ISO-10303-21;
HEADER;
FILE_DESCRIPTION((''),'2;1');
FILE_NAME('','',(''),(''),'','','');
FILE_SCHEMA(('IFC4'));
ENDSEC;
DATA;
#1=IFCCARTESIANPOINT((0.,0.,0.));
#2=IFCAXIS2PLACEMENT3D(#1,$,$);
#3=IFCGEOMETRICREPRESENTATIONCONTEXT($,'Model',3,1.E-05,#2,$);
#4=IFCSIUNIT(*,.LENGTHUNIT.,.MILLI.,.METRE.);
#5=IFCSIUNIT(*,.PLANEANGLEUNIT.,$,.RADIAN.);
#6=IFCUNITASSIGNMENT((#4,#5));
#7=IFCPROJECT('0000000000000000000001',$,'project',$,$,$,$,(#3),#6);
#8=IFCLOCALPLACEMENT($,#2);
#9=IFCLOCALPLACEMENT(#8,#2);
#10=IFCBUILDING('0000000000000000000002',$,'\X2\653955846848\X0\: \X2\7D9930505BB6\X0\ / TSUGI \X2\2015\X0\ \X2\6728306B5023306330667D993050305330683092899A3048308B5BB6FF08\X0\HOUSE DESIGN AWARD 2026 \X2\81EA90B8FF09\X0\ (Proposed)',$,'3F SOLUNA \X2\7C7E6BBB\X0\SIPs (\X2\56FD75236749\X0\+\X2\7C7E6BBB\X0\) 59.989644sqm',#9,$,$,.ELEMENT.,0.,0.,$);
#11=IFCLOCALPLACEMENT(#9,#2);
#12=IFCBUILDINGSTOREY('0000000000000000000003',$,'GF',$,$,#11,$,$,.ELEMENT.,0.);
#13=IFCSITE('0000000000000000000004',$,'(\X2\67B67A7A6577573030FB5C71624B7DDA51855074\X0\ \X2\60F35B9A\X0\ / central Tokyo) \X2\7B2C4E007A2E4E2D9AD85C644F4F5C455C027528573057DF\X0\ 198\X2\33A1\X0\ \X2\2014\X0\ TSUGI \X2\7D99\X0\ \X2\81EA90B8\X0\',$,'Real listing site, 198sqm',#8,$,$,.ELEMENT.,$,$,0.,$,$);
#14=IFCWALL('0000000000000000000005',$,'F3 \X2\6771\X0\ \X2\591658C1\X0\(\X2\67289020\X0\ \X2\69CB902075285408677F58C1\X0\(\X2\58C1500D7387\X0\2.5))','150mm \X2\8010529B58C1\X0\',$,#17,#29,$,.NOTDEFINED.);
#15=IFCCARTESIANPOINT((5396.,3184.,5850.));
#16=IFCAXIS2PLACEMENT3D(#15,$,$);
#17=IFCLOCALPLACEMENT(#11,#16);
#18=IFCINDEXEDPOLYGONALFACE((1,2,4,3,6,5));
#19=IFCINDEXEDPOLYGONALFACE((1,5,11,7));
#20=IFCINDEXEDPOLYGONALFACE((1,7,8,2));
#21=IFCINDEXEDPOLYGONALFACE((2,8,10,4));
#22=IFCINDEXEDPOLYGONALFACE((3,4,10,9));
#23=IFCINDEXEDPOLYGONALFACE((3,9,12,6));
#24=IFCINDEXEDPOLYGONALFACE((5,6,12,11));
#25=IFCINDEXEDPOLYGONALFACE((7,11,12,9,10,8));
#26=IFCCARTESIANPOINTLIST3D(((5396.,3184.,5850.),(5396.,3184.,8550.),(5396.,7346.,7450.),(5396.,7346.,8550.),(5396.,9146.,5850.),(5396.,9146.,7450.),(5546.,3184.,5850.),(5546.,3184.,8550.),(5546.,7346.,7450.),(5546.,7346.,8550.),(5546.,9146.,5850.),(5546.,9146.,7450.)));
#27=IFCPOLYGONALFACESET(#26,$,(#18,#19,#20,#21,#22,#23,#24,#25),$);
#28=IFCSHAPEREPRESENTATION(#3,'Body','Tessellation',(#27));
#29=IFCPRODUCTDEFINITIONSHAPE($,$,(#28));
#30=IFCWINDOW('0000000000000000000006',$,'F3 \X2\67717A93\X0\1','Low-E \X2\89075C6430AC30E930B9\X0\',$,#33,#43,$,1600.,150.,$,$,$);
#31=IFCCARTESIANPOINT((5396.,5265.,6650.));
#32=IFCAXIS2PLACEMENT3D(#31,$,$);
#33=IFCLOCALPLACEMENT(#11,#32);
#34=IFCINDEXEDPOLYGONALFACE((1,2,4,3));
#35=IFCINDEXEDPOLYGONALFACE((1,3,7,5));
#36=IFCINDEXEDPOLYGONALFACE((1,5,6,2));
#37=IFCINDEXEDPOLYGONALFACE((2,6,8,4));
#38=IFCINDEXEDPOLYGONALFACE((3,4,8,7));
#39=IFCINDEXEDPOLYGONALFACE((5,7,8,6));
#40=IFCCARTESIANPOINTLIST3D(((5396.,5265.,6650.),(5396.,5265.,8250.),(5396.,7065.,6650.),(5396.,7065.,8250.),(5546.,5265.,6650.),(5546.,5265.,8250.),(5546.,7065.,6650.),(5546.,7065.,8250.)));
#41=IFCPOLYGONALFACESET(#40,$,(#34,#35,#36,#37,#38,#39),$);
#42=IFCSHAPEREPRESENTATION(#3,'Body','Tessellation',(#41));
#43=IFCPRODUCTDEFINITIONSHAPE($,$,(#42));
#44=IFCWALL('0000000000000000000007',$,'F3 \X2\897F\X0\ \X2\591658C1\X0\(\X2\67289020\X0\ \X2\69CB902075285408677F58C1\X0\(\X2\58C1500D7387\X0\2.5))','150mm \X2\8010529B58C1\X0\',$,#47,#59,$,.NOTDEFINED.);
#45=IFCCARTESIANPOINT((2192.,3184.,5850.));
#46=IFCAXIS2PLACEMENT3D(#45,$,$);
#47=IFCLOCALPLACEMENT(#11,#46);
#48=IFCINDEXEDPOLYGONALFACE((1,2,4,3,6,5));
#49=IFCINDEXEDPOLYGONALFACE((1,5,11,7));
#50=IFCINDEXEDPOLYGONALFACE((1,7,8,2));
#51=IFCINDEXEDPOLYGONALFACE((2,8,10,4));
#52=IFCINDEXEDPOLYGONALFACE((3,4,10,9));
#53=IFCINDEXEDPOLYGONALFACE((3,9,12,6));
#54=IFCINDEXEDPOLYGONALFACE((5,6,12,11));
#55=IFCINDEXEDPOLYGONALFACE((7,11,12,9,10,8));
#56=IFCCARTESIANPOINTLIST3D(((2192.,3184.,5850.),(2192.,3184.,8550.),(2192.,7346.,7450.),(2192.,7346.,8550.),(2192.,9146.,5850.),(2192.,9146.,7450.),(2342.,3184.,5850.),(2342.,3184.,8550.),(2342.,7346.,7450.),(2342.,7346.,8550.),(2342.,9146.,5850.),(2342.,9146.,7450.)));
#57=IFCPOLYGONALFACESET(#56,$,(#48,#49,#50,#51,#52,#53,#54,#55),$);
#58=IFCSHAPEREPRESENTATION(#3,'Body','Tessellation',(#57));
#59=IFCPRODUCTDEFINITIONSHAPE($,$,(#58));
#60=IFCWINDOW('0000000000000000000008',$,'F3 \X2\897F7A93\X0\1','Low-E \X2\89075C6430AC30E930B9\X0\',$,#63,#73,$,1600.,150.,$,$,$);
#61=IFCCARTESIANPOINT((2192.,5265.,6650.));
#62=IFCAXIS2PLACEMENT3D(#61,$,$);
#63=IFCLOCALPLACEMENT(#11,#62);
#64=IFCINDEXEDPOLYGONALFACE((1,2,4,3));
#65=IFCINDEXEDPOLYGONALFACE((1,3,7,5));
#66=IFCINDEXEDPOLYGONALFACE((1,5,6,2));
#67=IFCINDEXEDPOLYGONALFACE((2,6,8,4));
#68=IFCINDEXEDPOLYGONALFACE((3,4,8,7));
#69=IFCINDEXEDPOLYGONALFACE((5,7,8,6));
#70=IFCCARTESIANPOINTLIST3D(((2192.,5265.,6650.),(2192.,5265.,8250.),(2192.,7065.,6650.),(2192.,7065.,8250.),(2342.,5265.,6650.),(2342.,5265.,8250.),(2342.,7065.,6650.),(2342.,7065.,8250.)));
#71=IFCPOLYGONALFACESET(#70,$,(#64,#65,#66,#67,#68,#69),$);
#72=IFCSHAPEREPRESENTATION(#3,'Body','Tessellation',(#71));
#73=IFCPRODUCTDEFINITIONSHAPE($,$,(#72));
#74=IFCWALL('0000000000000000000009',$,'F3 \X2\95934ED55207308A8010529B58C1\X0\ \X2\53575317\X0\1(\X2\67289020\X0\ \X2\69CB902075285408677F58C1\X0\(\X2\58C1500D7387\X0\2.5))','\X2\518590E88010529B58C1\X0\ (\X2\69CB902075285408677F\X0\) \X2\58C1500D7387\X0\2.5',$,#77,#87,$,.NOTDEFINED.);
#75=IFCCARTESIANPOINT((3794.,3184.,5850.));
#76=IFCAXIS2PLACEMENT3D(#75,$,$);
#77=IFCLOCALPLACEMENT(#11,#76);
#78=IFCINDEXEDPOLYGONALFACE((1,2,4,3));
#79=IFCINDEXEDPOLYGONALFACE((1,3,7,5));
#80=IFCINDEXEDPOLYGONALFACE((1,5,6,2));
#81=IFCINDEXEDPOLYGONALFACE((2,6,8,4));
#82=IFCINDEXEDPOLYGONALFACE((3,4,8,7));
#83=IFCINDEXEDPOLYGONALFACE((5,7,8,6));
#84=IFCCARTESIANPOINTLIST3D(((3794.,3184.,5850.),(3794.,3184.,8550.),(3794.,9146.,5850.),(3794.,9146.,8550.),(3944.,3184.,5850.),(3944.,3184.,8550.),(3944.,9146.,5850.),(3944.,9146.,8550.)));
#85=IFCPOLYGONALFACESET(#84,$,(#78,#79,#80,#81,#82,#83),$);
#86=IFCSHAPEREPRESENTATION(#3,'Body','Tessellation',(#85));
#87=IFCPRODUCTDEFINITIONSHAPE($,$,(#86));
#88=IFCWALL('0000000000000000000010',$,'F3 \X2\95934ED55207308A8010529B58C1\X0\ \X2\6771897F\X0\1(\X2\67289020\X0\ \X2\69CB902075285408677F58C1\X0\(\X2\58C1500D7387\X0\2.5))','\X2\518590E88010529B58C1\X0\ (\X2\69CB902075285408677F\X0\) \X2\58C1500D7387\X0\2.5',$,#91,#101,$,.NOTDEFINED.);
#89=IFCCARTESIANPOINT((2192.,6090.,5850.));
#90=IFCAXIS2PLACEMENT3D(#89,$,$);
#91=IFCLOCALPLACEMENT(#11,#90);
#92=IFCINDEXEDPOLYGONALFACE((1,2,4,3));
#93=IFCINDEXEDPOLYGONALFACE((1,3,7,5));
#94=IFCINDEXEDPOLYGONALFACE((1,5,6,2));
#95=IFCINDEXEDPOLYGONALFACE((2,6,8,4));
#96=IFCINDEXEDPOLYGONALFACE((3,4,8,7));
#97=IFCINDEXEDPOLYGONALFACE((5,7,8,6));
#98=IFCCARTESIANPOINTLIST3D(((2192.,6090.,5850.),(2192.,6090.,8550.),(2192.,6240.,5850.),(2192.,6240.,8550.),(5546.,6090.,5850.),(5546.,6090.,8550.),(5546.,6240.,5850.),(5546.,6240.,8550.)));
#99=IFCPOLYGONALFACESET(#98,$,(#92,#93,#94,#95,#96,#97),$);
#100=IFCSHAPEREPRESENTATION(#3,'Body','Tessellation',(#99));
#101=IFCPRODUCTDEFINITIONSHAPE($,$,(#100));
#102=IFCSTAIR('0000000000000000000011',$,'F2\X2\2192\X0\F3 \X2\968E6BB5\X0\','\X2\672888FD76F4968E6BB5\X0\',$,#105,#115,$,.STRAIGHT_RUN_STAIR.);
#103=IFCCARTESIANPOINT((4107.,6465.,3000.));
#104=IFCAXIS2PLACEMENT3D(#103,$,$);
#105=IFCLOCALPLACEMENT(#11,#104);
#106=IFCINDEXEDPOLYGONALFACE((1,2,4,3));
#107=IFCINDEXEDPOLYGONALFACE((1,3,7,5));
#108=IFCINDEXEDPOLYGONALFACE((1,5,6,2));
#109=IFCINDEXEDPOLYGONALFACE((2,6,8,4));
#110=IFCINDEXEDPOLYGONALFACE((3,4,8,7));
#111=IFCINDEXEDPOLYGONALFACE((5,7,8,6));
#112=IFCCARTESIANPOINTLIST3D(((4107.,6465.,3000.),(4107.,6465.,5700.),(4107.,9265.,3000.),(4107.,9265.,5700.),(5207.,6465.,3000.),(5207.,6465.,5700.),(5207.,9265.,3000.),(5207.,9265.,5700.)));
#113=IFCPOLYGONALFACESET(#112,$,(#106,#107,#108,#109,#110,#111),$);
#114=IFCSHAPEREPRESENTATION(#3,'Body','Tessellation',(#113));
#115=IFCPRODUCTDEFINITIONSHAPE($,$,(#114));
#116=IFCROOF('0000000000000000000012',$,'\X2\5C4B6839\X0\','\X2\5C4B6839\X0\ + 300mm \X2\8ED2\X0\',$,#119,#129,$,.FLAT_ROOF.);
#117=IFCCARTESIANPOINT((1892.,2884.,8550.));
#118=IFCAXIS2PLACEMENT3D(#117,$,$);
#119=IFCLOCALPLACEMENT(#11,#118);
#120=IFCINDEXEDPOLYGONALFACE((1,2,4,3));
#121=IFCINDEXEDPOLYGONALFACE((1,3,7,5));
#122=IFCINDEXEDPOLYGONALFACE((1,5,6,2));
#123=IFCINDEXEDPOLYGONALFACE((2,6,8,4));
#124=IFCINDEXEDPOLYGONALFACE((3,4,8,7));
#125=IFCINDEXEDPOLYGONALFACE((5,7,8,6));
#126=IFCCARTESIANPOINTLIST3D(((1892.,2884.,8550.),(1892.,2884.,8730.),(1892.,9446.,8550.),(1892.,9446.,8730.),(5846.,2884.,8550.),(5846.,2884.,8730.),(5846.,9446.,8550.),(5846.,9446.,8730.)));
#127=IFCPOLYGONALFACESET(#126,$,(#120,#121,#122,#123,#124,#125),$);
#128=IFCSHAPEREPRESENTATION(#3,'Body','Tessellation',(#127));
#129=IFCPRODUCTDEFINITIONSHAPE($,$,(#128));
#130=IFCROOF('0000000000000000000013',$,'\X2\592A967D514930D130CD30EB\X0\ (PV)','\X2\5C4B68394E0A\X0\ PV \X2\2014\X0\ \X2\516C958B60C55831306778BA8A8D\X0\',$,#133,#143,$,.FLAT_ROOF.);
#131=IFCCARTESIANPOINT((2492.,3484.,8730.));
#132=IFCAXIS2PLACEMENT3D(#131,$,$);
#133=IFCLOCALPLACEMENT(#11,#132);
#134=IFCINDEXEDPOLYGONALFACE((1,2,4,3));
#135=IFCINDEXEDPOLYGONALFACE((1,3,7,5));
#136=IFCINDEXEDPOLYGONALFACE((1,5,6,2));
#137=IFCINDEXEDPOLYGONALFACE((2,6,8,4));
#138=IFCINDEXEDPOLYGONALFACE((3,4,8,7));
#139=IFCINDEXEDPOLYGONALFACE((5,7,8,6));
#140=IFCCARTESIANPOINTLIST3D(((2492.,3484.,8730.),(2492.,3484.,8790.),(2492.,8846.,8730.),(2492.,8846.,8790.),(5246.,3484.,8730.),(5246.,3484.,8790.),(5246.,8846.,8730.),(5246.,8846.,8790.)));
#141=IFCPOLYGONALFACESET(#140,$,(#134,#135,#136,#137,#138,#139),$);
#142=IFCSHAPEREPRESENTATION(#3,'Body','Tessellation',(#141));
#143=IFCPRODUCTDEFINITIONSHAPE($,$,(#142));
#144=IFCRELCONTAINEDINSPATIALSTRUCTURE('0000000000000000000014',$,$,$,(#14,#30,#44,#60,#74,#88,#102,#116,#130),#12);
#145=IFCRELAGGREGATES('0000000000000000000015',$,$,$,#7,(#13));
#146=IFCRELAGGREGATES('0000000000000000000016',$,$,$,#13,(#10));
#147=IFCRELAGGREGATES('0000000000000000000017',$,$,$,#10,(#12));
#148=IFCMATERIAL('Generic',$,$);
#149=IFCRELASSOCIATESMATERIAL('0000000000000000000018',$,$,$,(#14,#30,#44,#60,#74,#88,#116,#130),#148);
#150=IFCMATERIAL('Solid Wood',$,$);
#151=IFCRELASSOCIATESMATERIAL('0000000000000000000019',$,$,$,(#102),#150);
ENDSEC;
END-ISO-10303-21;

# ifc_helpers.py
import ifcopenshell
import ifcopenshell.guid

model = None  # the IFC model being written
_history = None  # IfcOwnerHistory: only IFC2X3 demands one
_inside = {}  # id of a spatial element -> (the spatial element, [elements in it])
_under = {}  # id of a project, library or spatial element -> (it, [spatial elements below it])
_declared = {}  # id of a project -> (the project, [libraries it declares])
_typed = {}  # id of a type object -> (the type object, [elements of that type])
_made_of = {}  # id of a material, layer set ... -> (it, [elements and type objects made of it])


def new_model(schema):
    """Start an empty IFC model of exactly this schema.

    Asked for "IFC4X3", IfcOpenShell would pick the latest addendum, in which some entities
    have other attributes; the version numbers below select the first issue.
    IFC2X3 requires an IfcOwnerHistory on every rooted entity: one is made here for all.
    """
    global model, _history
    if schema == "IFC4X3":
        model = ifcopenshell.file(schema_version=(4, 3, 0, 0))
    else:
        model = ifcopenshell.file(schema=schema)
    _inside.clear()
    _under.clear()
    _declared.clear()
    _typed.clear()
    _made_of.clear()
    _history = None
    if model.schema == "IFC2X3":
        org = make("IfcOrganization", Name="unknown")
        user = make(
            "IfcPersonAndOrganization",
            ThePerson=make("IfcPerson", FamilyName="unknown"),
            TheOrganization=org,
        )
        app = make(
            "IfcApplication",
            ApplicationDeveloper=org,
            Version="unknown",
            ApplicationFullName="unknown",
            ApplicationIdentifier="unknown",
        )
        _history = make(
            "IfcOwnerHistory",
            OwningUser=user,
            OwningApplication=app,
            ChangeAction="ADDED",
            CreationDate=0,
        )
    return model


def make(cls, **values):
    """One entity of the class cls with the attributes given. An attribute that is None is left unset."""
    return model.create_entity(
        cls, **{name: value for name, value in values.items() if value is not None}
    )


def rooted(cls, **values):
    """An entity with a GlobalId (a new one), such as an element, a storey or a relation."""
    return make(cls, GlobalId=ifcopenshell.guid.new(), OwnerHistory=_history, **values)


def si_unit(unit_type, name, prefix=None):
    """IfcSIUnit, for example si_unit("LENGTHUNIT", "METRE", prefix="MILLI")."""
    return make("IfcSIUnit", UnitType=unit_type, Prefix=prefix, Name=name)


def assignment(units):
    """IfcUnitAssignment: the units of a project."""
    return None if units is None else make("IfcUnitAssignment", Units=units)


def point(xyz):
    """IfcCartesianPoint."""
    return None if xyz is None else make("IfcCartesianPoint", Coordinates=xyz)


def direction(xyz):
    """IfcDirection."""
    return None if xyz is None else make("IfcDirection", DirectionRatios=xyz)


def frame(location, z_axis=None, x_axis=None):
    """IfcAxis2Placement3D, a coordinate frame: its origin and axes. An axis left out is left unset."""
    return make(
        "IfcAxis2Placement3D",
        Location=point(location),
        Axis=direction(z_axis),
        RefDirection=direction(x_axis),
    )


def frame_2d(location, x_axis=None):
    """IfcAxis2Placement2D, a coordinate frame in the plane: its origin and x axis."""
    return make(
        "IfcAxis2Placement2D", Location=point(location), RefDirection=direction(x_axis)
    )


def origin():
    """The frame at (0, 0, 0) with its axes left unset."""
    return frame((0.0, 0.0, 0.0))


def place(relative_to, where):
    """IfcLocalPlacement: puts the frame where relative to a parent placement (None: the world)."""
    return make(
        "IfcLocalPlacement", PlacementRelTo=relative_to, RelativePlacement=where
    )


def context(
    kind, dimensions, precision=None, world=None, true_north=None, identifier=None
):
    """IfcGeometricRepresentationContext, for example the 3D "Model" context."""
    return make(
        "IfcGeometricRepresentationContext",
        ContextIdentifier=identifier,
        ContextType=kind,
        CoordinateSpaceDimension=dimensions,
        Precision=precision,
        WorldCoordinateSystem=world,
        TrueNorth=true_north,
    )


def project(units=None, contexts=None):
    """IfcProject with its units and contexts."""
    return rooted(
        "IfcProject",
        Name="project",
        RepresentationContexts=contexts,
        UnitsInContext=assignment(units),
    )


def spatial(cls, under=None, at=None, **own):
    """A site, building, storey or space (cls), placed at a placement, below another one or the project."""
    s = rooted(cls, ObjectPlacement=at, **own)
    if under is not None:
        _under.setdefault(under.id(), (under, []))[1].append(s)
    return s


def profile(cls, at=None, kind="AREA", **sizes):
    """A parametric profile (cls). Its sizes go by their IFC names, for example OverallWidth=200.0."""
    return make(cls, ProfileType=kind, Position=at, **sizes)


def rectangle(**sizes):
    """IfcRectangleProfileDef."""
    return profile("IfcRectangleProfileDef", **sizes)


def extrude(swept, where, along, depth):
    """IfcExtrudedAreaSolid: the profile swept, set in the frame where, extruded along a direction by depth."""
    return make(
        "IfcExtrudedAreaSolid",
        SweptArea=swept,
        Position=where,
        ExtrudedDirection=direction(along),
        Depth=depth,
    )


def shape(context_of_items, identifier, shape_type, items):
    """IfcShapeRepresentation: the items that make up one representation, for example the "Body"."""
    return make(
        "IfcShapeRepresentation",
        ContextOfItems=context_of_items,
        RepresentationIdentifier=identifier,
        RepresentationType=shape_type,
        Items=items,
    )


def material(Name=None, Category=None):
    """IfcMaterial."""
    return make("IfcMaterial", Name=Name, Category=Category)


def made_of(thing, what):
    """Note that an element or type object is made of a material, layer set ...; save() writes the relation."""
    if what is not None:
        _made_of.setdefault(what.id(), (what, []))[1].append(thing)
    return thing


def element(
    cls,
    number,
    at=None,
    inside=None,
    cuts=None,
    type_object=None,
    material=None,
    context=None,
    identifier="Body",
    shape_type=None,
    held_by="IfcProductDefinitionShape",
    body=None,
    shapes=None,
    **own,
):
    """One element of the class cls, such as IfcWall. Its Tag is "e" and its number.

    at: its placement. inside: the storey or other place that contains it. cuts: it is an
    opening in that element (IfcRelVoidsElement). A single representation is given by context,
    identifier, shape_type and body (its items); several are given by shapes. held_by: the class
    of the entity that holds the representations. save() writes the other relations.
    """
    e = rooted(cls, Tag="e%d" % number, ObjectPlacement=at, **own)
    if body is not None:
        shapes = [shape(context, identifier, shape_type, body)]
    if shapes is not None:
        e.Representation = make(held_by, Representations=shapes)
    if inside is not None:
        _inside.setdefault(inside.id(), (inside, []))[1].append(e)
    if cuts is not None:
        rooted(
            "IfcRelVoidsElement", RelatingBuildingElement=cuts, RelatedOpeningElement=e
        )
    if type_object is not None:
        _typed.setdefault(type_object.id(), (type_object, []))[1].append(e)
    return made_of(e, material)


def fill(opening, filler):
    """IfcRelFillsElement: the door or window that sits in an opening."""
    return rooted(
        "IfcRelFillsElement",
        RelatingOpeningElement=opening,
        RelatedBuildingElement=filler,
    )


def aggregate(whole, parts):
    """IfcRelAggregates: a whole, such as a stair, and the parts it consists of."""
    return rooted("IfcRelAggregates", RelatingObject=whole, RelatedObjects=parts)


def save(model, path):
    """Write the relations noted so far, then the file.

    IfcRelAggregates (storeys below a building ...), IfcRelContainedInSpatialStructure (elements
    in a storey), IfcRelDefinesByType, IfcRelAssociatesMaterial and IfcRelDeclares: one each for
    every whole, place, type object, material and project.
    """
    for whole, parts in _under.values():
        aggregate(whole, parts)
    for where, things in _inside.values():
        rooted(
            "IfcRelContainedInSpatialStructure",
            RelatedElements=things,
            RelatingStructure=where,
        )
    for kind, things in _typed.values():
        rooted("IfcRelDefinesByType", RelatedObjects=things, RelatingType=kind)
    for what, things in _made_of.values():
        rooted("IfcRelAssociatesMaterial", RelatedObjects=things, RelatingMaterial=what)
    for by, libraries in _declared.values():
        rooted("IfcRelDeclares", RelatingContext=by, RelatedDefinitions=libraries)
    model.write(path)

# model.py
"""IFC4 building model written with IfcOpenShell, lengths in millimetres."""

from ifc_helpers import new_model, si_unit, frame, frame_2d, origin, place, context, project, spatial, rectangle, extrude, material, element, fill, save


model = new_model("IFC4")

# Units and contexts
model_context = context("Model", 3, precision=1e-05, world=origin())
ifc_project = project(units=[si_unit("LENGTHUNIT", "METRE", prefix="MILLI"), si_unit("PLANEANGLEUNIT", "RADIAN")], contexts=[model_context])

# Site, building, storey
site_placement = place(None, origin())
site = spatial("IfcSite", under=ifc_project, at=site_placement, Name="(架空敷地・山手線内側 想定 / central Tokyo) 第一種中高層住居専用地域 198㎡ — TSUGI 継 自邸", ObjectType="Real listing site, 198sqm", CompositionType="ELEMENT", RefElevation=0.0)
building_placement = place(site_placement, origin())
building = spatial("IfcBuilding", under=site, at=building_placement, Name="改善案: 継ぐ家 / TSUGI ― 木に倣って継ぐことを覚える家（HOUSE DESIGN AWARD 2026 自邸） (Proposed)", ObjectType="3F SOLUNA 籾殻SIPs (国産杉+籾殻) 59.989644sqm", CompositionType="ELEMENT", ElevationOfRefHeight=0.0, ElevationOfTerrain=0.0)
storey_placement = place(building_placement, origin())
storey = spatial("IfcBuildingStorey", under=building, at=storey_placement, Name="GF", CompositionType="ELEMENT", Elevation=0.0)

# Shared definitions
ifc_material_1 = material(Name="Generic")

# Walls, openings, windows
wall_1_placement = place(storey_placement, frame((5396.0, 3184.0, 5850.0)))
wall_1 = element("IfcWall", 1, at=wall_1_placement, inside=storey, material=ifc_material_1, Name="F3 東 外壁(木造 構造用合板壁(壁倍率2.5))", Description="150mm 耐力壁", PredefinedType="NOTDEFINED", context=model_context, shape_type="SweptSolid", body=[
    extrude(rectangle(XDim=150.0, YDim=5962.0, at=frame_2d((75.0, 2981.0))), frame((5396.0, 3184.0, 5850.0)), (0.0, 0.0, 1.0), 2700.0),
])
opening_1_placement = place(storey_placement, frame((5396.0, 5265.0, 6650.0)))
opening_1 = element("IfcOpeningElement", 2, at=opening_1_placement, cuts=wall_1, PredefinedType="NOTDEFINED", context=model_context, shape_type="SweptSolid", body=[
    extrude(rectangle(XDim=150.0, YDim=1800.0, at=frame_2d((75.0, 900.0))), frame((5396.0, 5265.0, 6650.0)), (0.0, 0.0, 1.0), 1600.0),
])
window_1_placement = place(storey_placement, frame((5396.0, 5265.0, 6650.0)))
window_1 = element("IfcWindow", 3, at=window_1_placement, inside=storey, material=ifc_material_1, Name="F3 東窓1", Description="Low-E 複層ガラス", OverallHeight=1600.0, OverallWidth=150.0, context=model_context, shape_type="SweptSolid", body=[
    extrude(rectangle(XDim=150.0, YDim=1800.0, at=frame_2d((75.0, 900.0))), frame((5396.0, 5265.0, 6650.0)), (0.0, 0.0, 1.0), 1600.0),
])
fill(opening_1, window_1)
wall_2_placement = place(storey_placement, frame((2192.0, 3184.0, 5850.0)))
wall_2 = element("IfcWall", 4, at=wall_2_placement, inside=storey, material=ifc_material_1, Name="F3 西 外壁(木造 構造用合板壁(壁倍率2.5))", Description="150mm 耐力壁", PredefinedType="NOTDEFINED", context=model_context, shape_type="SweptSolid", body=[
    extrude(rectangle(XDim=150.0, YDim=5962.0, at=frame_2d((75.0, 2981.0))), frame((2192.0, 3184.0, 5850.0)), (0.0, 0.0, 1.0), 2700.0),
])
opening_2_placement = place(storey_placement, frame((2192.0, 5265.0, 6650.0)))
opening_2 = element("IfcOpeningElement", 5, at=opening_2_placement, cuts=wall_2, PredefinedType="NOTDEFINED", context=model_context, shape_type="SweptSolid", body=[
    extrude(rectangle(XDim=150.0, YDim=1800.0, at=frame_2d((75.0, 900.0))), frame((2192.0, 5265.0, 6650.0)), (0.0, 0.0, 1.0), 1600.0),
])
window_2_placement = place(storey_placement, frame((2192.0, 5265.0, 6650.0)))
window_2 = element("IfcWindow", 6, at=window_2_placement, inside=storey, material=ifc_material_1, Name="F3 西窓1", Description="Low-E 複層ガラス", OverallHeight=1600.0, OverallWidth=150.0, context=model_context, shape_type="SweptSolid", body=[
    extrude(rectangle(XDim=150.0, YDim=1800.0, at=frame_2d((75.0, 900.0))), frame((2192.0, 5265.0, 6650.0)), (0.0, 0.0, 1.0), 1600.0),
])
fill(opening_2, window_2)

# Walls
wall_3_placement = place(storey_placement, frame((3794.0, 3184.0, 5850.0)))
element("IfcWall", 7, at=wall_3_placement, inside=storey, material=ifc_material_1, Name="F3 間仕切り耐力壁 南北1(木造 構造用合板壁(壁倍率2.5))", Description="内部耐力壁 (構造用合板) 壁倍率2.5", PredefinedType="NOTDEFINED", context=model_context, shape_type="SweptSolid", body=[
    extrude(rectangle(XDim=150.0, YDim=5962.0, at=frame_2d((75.0, 2981.0))), frame((3794.0, 3184.0, 5850.0)), (0.0, 0.0, 1.0), 2700.0),
])
wall_4_placement = place(storey_placement, frame((2192.0, 6090.0, 5850.0)))
element("IfcWall", 8, at=wall_4_placement, inside=storey, material=ifc_material_1, Name="F3 間仕切り耐力壁 東西1(木造 構造用合板壁(壁倍率2.5))", Description="内部耐力壁 (構造用合板) 壁倍率2.5", PredefinedType="NOTDEFINED", context=model_context, shape_type="SweptSolid", body=[
    extrude(rectangle(XDim=3354.0, YDim=150.0, at=frame_2d((1677.0, 75.0))), frame((2192.0, 6090.0, 5850.0)), (0.0, 0.0, 1.0), 2700.0),
])

# Stair
ifc_material_2 = material(Name="Solid Wood")
stair_placement = place(storey_placement, frame((4107.0, 6465.0, 3000.0)))
element("IfcStair", 9, at=stair_placement, inside=storey, material=ifc_material_2, Name="F2→F3 階段", Description="木製直階段", PredefinedType="STRAIGHT_RUN_STAIR", context=model_context, shape_type="SweptSolid", body=[
    extrude(rectangle(XDim=1100.0, YDim=2800.0, at=frame_2d((550.0, 1400.0))), frame((4107.0, 6465.0, 3000.0)), (0.0, 0.0, 1.0), 2700.0),
])

# Roofs
roof_1_placement = place(storey_placement, frame((1892.0, 2884.0, 8550.0)))
element("IfcRoof", 10, at=roof_1_placement, inside=storey, material=ifc_material_1, Name="屋根", Description="屋根 + 300mm 軒", PredefinedType="FLAT_ROOF", context=model_context, shape_type="SweptSolid", body=[
    extrude(rectangle(XDim=3954.0, YDim=6562.0, at=frame_2d((1977.0, 3281.0))), frame((1892.0, 2884.0, 8550.0)), (0.0, 0.0, 1.0), 180.0),
])
roof_2_placement = place(storey_placement, frame((2492.0, 3484.0, 8730.0)))
element("IfcRoof", 11, at=roof_2_placement, inside=storey, material=ifc_material_1, Name="太陽光パネル (PV)", Description="屋根上 PV — 公開情報で確認", PredefinedType="FLAT_ROOF", context=model_context, shape_type="SweptSolid", body=[
    extrude(rectangle(XDim=2754.0, YDim=5362.0, at=frame_2d((1377.0, 2681.0))), frame((2492.0, 3484.0, 8730.0)), (0.0, 0.0, 1.0), 60.0),
])

save(model, "model.ifc")
